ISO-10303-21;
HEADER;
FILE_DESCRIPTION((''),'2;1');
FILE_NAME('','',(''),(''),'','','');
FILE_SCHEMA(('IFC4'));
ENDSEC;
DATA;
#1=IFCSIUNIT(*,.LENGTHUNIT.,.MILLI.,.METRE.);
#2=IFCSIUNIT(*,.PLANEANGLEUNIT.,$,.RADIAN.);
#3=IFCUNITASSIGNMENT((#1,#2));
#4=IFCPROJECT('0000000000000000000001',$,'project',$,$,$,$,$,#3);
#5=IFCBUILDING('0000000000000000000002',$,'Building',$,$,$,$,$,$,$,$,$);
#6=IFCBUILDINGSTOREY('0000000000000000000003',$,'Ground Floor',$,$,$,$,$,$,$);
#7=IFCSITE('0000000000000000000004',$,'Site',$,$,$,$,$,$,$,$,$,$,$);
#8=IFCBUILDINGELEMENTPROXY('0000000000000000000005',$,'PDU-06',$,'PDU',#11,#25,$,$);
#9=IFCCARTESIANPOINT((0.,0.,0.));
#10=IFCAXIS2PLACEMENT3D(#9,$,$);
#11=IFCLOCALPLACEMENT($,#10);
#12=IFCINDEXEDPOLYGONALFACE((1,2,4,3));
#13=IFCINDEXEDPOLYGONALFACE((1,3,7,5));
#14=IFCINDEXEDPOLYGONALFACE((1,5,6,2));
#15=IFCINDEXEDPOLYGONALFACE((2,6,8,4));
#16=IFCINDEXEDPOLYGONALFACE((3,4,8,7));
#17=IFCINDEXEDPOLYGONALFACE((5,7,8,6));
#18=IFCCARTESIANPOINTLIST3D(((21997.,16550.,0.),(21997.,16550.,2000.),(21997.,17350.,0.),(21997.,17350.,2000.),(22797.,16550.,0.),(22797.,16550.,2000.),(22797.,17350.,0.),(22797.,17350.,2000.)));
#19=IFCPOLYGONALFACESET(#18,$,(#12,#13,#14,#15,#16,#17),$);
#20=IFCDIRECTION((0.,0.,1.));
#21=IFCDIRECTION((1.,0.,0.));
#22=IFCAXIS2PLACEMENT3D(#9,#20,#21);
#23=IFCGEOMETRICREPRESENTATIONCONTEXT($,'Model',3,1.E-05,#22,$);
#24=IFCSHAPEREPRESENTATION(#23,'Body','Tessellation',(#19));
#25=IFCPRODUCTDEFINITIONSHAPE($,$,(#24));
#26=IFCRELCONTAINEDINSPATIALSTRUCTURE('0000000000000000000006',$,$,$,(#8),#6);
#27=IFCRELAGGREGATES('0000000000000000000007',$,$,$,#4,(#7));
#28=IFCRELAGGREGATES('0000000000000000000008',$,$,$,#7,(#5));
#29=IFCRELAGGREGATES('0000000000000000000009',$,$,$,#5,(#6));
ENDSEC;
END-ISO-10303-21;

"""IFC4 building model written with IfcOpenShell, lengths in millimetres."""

from ifc_helpers import new_model, si_unit, frame, origin_with_axes, place, context, project, spatial, rectangle, extrude, element, save


model = new_model("IFC4")

# Units and contexts
model_context = context("Model", 3, precision=1e-05, world=origin_with_axes())
ifc_project = project(units=[si_unit("LENGTHUNIT", "METRE", prefix="MILLI"), si_unit("PLANEANGLEUNIT", "RADIAN")])

# Site, building, storey
site = spatial("IfcSite", under=ifc_project, Name="Site")
building = spatial("IfcBuilding", under=site, Name="Building")
storey = spatial("IfcBuildingStorey", under=building, Name="Ground Floor")

# Building element proxy
proxy_1_placement = place(None, origin_with_axes())
element("IfcBuildingElementProxy", 1, at=proxy_1_placement, inside=storey, Name="PDU-06", ObjectType="PDU", context=model_context, shape_type="SweptSolid", body=[
    extrude(rectangle(XDim=800.0, YDim=800.0), frame((22397.0, 16950.0, 0.0), z_axis=(0.0, 0.0, 1.0), x_axis=(1.0, 0.0, 0.0)), (0.0, 0.0, 1.0), 2000.0),
])

save(model, "model.ifc")
